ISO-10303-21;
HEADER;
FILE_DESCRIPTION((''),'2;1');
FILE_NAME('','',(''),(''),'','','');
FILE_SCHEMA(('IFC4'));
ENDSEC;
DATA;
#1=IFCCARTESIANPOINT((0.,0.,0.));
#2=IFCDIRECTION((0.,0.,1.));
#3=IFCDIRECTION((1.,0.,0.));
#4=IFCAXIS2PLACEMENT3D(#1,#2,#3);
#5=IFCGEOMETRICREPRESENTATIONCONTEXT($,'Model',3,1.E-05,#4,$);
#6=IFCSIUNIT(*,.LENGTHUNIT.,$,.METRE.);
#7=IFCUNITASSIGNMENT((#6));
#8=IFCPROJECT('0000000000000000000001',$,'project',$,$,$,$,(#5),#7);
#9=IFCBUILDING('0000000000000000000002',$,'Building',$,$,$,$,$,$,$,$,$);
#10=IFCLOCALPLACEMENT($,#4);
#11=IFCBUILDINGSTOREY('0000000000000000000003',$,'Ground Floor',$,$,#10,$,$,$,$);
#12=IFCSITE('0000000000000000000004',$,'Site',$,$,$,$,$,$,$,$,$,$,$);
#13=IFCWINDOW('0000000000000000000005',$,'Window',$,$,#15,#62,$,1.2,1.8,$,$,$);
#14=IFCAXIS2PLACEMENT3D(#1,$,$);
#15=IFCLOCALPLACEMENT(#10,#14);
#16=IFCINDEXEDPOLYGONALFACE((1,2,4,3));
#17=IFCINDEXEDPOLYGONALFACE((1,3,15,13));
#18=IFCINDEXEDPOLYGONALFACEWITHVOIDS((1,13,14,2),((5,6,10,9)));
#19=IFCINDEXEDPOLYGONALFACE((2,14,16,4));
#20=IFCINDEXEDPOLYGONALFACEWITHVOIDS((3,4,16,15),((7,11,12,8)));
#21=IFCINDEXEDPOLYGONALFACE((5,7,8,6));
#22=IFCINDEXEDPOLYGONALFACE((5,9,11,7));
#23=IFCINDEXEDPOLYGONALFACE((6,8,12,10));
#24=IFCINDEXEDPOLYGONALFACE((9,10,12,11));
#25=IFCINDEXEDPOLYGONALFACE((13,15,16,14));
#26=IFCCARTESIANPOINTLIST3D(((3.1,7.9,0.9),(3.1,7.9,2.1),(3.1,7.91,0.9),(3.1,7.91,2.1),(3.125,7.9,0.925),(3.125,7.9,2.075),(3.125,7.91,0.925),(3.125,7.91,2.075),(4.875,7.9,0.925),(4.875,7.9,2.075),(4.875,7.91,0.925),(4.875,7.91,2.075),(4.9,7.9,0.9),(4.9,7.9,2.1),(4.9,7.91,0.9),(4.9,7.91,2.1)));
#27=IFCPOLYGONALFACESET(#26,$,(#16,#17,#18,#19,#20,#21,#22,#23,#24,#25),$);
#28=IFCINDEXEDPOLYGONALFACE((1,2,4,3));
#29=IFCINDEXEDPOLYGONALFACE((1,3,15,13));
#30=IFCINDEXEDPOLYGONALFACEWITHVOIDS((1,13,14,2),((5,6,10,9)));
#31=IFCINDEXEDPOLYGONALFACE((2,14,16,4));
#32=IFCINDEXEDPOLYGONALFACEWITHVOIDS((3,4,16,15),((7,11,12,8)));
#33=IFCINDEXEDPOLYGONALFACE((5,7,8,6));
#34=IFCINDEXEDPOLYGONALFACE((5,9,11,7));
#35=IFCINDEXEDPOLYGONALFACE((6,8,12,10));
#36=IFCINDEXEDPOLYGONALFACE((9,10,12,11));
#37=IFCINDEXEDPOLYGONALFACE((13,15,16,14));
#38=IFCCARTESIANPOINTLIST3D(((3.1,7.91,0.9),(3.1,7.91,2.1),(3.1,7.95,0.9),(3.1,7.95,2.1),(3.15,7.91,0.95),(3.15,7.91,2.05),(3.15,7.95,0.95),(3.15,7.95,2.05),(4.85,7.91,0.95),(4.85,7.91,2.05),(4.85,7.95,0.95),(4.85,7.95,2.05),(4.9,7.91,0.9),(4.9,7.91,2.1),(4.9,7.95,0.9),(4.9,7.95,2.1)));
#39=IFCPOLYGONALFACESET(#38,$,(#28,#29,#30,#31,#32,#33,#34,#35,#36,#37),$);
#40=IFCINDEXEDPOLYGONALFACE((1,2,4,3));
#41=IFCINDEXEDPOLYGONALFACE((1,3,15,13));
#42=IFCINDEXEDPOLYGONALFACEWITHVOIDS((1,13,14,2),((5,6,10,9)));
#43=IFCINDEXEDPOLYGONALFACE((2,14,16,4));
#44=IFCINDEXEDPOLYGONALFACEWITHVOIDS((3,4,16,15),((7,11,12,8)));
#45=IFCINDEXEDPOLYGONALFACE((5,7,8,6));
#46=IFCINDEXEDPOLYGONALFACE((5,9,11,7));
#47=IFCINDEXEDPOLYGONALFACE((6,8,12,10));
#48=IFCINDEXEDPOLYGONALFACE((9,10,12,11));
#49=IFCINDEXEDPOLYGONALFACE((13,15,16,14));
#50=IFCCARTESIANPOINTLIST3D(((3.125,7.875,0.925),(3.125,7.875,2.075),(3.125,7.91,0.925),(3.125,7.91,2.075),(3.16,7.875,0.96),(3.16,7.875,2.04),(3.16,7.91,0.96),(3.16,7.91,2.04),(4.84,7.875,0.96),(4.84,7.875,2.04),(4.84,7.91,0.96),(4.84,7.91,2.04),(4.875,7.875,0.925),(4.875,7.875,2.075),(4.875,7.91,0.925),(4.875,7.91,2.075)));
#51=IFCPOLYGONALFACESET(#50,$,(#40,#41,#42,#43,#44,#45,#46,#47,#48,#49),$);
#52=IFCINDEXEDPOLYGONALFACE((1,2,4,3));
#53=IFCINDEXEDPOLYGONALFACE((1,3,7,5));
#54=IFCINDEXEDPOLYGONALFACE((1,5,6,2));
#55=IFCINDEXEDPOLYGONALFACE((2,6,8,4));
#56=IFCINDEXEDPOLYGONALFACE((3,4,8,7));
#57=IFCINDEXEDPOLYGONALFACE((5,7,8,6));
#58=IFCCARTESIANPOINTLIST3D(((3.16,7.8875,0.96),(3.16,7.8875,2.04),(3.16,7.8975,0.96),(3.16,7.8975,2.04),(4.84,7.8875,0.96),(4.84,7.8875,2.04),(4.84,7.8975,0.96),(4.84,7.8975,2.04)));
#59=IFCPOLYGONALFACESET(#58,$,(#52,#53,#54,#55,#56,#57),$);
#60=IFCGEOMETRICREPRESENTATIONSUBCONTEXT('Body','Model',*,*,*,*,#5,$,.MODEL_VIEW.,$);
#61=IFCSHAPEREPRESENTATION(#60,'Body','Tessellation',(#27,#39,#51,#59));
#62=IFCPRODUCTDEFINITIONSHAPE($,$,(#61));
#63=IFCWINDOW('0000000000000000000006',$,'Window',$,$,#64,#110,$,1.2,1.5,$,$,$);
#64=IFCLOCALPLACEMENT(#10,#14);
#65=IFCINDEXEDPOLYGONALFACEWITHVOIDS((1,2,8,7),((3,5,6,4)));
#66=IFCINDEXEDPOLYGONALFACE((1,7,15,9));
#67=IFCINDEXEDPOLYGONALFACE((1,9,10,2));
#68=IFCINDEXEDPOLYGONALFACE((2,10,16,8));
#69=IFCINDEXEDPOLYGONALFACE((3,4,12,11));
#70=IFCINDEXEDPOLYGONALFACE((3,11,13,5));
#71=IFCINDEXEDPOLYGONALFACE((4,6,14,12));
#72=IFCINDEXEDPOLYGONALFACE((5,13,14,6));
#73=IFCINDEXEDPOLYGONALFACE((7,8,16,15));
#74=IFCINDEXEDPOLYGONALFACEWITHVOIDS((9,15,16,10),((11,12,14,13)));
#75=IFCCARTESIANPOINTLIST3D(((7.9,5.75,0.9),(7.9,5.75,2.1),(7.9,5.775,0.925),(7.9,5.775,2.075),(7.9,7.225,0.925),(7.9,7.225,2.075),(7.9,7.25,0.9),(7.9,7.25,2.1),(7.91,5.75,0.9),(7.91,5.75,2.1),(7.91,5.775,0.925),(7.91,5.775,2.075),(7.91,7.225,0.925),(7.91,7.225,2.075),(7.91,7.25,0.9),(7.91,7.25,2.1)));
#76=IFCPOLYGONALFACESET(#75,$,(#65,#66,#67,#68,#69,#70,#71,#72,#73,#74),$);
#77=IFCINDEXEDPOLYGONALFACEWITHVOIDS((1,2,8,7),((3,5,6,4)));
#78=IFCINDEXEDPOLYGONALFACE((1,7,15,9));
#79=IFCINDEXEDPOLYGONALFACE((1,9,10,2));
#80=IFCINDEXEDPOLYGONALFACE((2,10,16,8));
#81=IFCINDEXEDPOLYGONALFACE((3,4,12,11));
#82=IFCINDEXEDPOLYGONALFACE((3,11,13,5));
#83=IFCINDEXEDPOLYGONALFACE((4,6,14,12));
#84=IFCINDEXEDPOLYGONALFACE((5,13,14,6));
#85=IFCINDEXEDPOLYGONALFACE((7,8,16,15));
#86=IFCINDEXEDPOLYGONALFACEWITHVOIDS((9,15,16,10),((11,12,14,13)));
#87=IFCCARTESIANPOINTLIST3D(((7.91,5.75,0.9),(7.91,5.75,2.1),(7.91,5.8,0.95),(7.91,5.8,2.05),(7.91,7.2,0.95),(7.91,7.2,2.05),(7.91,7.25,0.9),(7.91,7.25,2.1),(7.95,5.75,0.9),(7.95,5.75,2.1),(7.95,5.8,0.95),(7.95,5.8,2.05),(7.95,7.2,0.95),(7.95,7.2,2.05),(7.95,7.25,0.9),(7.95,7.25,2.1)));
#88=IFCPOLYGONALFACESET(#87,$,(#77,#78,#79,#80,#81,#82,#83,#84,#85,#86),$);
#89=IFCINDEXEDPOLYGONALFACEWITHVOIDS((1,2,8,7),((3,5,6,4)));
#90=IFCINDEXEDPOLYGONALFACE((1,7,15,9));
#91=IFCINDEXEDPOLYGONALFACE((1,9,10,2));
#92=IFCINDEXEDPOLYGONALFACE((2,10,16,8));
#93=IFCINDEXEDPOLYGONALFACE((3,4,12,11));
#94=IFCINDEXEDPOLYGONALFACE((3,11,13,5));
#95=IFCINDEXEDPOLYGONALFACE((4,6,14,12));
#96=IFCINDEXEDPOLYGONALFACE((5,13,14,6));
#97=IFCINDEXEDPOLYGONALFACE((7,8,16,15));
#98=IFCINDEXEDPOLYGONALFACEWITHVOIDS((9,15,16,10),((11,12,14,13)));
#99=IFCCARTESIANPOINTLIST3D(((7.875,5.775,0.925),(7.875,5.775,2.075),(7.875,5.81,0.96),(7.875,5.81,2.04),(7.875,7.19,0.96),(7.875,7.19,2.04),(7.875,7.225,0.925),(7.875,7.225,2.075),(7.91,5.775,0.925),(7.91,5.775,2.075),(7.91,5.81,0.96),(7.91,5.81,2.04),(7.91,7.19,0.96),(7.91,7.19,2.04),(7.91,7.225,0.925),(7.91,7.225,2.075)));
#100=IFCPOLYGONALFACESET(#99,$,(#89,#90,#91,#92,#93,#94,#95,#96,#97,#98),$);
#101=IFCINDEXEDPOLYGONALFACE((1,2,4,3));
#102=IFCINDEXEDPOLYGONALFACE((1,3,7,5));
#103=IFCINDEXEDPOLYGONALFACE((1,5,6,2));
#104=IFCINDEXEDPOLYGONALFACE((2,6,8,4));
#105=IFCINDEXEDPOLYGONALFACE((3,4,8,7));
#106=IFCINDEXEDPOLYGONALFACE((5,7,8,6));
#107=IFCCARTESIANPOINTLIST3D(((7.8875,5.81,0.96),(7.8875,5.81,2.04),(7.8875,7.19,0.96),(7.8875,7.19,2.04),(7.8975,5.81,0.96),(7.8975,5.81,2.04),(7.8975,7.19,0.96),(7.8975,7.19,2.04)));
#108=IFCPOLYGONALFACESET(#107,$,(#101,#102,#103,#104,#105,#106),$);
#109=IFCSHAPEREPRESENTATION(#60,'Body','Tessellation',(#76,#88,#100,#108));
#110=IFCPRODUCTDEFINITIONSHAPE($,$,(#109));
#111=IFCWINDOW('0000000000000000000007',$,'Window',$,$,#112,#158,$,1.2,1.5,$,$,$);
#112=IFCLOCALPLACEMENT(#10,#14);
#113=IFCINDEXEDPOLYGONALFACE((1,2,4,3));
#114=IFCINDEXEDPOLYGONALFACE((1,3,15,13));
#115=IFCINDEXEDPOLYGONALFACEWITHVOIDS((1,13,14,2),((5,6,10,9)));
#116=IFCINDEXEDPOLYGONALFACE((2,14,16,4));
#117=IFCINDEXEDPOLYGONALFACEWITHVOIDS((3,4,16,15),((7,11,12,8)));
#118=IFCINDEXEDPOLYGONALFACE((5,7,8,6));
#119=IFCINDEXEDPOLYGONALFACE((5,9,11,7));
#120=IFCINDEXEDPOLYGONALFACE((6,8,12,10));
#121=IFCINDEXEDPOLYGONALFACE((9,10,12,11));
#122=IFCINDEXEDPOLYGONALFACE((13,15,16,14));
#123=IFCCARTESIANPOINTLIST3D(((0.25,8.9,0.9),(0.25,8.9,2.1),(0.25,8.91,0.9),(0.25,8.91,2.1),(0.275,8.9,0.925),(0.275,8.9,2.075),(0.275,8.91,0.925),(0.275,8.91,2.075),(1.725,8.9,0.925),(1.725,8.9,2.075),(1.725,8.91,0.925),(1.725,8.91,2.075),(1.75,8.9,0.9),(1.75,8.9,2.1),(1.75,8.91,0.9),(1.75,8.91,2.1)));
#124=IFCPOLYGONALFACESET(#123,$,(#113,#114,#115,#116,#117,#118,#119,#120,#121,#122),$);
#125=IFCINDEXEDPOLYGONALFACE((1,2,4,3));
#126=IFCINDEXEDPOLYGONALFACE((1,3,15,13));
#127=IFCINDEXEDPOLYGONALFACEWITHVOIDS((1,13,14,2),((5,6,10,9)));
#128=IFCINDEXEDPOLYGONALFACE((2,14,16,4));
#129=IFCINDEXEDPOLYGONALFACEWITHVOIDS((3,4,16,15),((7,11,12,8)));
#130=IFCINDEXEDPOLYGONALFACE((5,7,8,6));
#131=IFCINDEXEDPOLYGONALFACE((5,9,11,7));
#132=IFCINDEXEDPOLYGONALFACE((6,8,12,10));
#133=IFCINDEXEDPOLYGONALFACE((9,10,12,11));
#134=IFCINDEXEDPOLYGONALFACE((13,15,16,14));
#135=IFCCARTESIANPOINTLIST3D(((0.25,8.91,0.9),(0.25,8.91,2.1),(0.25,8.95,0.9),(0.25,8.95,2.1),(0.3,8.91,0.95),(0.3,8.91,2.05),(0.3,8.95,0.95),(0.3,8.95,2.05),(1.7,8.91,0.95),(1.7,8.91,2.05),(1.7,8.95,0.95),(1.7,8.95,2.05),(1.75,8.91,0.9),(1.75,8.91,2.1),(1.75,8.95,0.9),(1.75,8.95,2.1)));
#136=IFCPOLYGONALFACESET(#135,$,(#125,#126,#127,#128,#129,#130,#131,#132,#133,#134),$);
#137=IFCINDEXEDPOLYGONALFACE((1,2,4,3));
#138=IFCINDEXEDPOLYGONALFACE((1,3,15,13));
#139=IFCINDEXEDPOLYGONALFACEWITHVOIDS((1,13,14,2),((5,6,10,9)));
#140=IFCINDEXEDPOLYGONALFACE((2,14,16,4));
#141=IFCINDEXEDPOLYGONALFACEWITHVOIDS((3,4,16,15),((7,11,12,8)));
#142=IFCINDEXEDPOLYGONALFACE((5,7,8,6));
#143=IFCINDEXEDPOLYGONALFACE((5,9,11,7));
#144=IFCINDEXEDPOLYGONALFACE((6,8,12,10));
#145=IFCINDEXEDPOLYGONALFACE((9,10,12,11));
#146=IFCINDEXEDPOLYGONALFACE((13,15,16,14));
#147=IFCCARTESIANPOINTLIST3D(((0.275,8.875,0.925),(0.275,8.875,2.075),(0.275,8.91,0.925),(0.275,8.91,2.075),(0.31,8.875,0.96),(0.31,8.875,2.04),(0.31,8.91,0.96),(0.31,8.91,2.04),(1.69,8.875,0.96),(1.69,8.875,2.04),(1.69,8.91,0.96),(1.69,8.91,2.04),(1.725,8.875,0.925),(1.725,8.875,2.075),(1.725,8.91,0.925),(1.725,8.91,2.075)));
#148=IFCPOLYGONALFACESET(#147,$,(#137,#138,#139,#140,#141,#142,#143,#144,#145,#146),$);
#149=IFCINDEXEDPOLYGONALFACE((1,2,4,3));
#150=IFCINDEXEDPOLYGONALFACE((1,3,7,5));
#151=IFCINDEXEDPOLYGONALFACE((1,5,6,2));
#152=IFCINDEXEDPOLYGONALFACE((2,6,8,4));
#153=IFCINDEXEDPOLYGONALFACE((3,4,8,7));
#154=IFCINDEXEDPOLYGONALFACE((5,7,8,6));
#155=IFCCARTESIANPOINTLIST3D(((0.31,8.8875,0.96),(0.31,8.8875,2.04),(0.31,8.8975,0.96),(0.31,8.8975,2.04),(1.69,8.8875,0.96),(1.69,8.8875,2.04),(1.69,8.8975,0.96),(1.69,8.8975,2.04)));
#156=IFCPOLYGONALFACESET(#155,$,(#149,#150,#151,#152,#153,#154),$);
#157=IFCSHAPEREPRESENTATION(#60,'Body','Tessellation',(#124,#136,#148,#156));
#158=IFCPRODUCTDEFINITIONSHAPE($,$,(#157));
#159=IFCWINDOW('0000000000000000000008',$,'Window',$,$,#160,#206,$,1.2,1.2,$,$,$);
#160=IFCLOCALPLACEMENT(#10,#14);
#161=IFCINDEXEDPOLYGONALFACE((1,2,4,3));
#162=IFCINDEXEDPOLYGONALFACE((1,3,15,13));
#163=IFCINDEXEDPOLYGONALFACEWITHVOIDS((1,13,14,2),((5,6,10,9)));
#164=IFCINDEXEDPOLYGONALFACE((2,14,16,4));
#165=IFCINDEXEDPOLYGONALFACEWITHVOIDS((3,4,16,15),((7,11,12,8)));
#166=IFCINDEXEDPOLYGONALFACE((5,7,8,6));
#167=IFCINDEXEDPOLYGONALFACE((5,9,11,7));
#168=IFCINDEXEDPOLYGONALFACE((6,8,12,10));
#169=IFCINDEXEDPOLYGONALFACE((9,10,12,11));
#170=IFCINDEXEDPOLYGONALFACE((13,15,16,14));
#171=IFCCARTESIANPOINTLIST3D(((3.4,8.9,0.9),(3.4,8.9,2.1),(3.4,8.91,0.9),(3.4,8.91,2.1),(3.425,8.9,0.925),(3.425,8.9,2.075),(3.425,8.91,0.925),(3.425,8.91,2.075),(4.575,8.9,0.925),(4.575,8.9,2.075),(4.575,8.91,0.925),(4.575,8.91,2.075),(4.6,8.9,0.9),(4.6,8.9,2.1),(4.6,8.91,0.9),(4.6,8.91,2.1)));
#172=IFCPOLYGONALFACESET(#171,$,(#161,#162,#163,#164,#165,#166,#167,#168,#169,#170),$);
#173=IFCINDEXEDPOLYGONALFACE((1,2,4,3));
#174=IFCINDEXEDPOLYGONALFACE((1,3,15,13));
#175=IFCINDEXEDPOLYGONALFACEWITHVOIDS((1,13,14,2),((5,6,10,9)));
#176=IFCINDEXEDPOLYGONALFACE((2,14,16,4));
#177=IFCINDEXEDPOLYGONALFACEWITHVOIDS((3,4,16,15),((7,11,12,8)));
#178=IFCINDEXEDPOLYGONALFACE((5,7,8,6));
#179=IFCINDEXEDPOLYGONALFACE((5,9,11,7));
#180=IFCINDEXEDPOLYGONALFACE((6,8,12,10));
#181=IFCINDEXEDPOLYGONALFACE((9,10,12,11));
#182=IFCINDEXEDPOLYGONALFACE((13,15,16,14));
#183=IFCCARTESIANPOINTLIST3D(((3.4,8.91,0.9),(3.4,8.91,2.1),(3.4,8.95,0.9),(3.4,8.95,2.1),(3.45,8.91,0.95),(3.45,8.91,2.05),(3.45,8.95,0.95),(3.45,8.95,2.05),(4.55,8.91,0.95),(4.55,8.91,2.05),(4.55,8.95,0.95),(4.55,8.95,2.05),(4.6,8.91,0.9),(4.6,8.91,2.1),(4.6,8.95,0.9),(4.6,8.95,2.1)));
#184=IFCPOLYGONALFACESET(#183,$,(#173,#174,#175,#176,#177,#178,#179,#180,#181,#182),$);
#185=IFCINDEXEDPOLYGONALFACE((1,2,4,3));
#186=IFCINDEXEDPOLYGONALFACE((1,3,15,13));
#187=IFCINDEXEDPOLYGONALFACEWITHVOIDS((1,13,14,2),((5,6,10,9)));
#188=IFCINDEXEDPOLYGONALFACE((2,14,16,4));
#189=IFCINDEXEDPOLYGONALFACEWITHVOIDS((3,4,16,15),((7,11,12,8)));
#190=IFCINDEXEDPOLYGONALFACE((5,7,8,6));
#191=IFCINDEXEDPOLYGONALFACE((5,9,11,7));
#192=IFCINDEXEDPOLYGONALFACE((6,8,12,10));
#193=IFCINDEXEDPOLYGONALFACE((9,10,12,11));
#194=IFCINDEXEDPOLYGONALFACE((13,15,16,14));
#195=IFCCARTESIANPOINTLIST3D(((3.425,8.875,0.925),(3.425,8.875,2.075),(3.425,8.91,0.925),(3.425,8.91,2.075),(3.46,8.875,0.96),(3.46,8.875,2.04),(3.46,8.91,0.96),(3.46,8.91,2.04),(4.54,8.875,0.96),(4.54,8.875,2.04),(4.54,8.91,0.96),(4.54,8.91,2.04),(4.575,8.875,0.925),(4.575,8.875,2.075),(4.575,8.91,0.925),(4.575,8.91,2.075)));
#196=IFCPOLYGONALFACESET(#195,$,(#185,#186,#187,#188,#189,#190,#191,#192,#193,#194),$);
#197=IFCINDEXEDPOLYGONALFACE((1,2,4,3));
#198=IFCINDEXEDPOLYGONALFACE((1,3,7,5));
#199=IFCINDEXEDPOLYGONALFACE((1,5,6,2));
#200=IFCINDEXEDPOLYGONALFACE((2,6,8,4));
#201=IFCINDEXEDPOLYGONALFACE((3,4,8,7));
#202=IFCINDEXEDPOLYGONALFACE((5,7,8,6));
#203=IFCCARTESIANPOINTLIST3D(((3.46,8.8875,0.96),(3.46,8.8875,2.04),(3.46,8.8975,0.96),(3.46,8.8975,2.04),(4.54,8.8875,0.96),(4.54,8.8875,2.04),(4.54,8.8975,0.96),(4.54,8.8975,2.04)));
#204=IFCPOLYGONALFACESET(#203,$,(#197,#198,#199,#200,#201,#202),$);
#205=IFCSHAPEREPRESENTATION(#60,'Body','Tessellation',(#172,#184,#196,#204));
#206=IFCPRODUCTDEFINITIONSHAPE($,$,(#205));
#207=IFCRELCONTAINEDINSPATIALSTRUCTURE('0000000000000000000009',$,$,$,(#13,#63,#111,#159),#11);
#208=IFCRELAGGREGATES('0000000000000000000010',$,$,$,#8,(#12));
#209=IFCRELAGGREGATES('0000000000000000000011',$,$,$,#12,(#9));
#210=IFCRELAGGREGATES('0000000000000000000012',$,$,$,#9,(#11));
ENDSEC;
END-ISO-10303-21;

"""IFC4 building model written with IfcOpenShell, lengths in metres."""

from ifc_helpers import new_model, si_unit, frame, origin_with_axes, place, context, subcontext, project, spatial, line, indexed_curve, outline, extrude, element, save


model = new_model("IFC4")

# Units and contexts
model_context = context("Model", 3, precision=1e-05, world=origin_with_axes())
body_context = subcontext(model_context, "Body", "Model", "MODEL_VIEW")
ifc_project = project(units=[si_unit("LENGTHUNIT", "METRE")], contexts=[model_context])

# Site, building, storey
site = spatial("IfcSite", under=ifc_project, Name="Site")
building = spatial("IfcBuilding", under=site, Name="Building")
storey_placement = place(None, origin_with_axes())
storey = spatial("IfcBuildingStorey", under=building, at=storey_placement, Name="Ground Floor")

# Windows
window_1_placement = place(storey_placement, frame((4.9, 8.0, 0.9), z_axis=(0.0, 0.0, 1.0), x_axis=(-1.0, 0.0, 0.0)))
element("IfcWindow", 1, at=window_1_placement, inside=storey, Name="Window", OverallHeight=1.2, OverallWidth=1.8, context=body_context, shape_type="SweptSolid", body=[
    extrude(outline(indexed_curve([(0.0, 0.0), (1.8, 0.0), (1.8, 1.2), (0.0, 1.2)], segments=[line(1, 2, 3, 4, 1)]), holes=[indexed_curve([(0.025, 0.025), (1.775, 0.025), (1.775, 1.175), (0.025, 1.175)], segments=[line(1, 2, 3, 4, 1)])]), frame((0.0, 0.09, 0.0), z_axis=(0.0, -1.0, 0.0), x_axis=(1.0, 0.0, 0.0)), (0.0, 0.0, -1.0), 0.01),
    extrude(outline(indexed_curve([(0.0, 0.0), (1.8, 0.0), (1.8, 1.2), (0.0, 1.2)], segments=[line(1, 2, 3, 4, 1)]), holes=[indexed_curve([(0.05, 0.05), (1.75, 0.05), (1.75, 1.15), (0.05, 1.15)], segments=[line(1, 2, 3, 4, 1)])]), frame((0.0, 0.05, 0.0), z_axis=(0.0, -1.0, 0.0), x_axis=(1.0, 0.0, 0.0)), (0.0, 0.0, -1.0), 0.04),
    extrude(outline(indexed_curve([(0.0, 0.0), (1.75, 0.0), (1.75, 1.15), (0.0, 1.15)], segments=[line(1, 2, 3, 4, 1)]), holes=[indexed_curve([(0.035, 0.035), (1.715, 0.035), (1.715, 1.115), (0.035, 1.115)], segments=[line(1, 2, 3, 4, 1)])]), frame((0.025, 0.09, 0.025), z_axis=(0.0, -1.0, 0.0), x_axis=(1.0, 0.0, 0.0)), (0.0, 0.0, -1.0), 0.035),
    extrude(outline(indexed_curve([(0.035, 0.035), (1.715, 0.035), (1.715, 1.115), (0.035, 1.115)], segments=[line(1, 2, 3, 4, 1)])), frame((0.025, 0.1025, 0.025), z_axis=(0.0, -1.0, 0.0), x_axis=(1.0, 0.0, 0.0)), (0.0, 0.0, -1.0), 0.01),
])
for number, where, z_axis, x_axis, name in (
    (2, (8.0, 5.75, 0.9), (0.0, 0.0, 1.0), (0.0, 1.0, 0.0), "Window"),
    (3, (1.75, 9.0, 0.9), (0.0, 0.0, 1.0), (-1.0, 0.0, 0.0), "Window"),
):
    element("IfcWindow", number, at=place(storey_placement, frame(where, z_axis=z_axis, x_axis=x_axis)), inside=storey, Name=name, OverallHeight=1.2, OverallWidth=1.5, context=body_context, shape_type="SweptSolid", body=[
        extrude(outline(indexed_curve([(0.0, 0.0), (1.5, 0.0), (1.5, 1.2), (0.0, 1.2)], segments=[line(1, 2, 3, 4, 1)]), holes=[indexed_curve([(0.025, 0.025), (1.475, 0.025), (1.475, 1.175), (0.025, 1.175)], segments=[line(1, 2, 3, 4, 1)])]), frame((0.0, 0.09, 0.0), z_axis=(0.0, -1.0, 0.0), x_axis=(1.0, 0.0, 0.0)), (0.0, 0.0, -1.0), 0.01),
        extrude(outline(indexed_curve([(0.0, 0.0), (1.5, 0.0), (1.5, 1.2), (0.0, 1.2)], segments=[line(1, 2, 3, 4, 1)]), holes=[indexed_curve([(0.05, 0.05), (1.45, 0.05), (1.45, 1.15), (0.05, 1.15)], segments=[line(1, 2, 3, 4, 1)])]), frame((0.0, 0.05, 0.0), z_axis=(0.0, -1.0, 0.0), x_axis=(1.0, 0.0, 0.0)), (0.0, 0.0, -1.0), 0.04),
        extrude(outline(indexed_curve([(0.0, 0.0), (1.45, 0.0), (1.45, 1.15), (0.0, 1.15)], segments=[line(1, 2, 3, 4, 1)]), holes=[indexed_curve([(0.035, 0.035), (1.415, 0.035), (1.415, 1.115), (0.035, 1.115)], segments=[line(1, 2, 3, 4, 1)])]), frame((0.025, 0.09, 0.025), z_axis=(0.0, -1.0, 0.0), x_axis=(1.0, 0.0, 0.0)), (0.0, 0.0, -1.0), 0.035),
        extrude(outline(indexed_curve([(0.035, 0.035), (1.415, 0.035), (1.415, 1.115), (0.035, 1.115)], segments=[line(1, 2, 3, 4, 1)])), frame((0.025, 0.1025, 0.025), z_axis=(0.0, -1.0, 0.0), x_axis=(1.0, 0.0, 0.0)), (0.0, 0.0, -1.0), 0.01),
    ])
window_2_placement = place(storey_placement, frame((4.6, 9.0, 0.9), z_axis=(0.0, 0.0, 1.0), x_axis=(-1.0, 0.0, 0.0)))
element("IfcWindow", 4, at=window_2_placement, inside=storey, Name="Window", OverallHeight=1.2, OverallWidth=1.2, context=body_context, shape_type="SweptSolid", body=[
    extrude(outline(indexed_curve([(0.0, 0.0), (1.2, 0.0), (1.2, 1.2), (0.0, 1.2)], segments=[line(1, 2, 3, 4, 1)]), holes=[indexed_curve([(0.025, 0.025), (1.175, 0.025), (1.175, 1.175), (0.025, 1.175)], segments=[line(1, 2, 3, 4, 1)])]), frame((0.0, 0.09, 0.0), z_axis=(0.0, -1.0, 0.0), x_axis=(1.0, 0.0, 0.0)), (0.0, 0.0, -1.0), 0.01),
    extrude(outline(indexed_curve([(0.0, 0.0), (1.2, 0.0), (1.2, 1.2), (0.0, 1.2)], segments=[line(1, 2, 3, 4, 1)]), holes=[indexed_curve([(0.05, 0.05), (1.15, 0.05), (1.15, 1.15), (0.05, 1.15)], segments=[line(1, 2, 3, 4, 1)])]), frame((0.0, 0.05, 0.0), z_axis=(0.0, -1.0, 0.0), x_axis=(1.0, 0.0, 0.0)), (0.0, 0.0, -1.0), 0.04),
    extrude(outline(indexed_curve([(0.0, 0.0), (1.15, 0.0), (1.15, 1.15), (0.0, 1.15)], segments=[line(1, 2, 3, 4, 1)]), holes=[indexed_curve([(0.035, 0.035), (1.115, 0.035), (1.115, 1.115), (0.035, 1.115)], segments=[line(1, 2, 3, 4, 1)])]), frame((0.025, 0.09, 0.025), z_axis=(0.0, -1.0, 0.0), x_axis=(1.0, 0.0, 0.0)), (0.0, 0.0, -1.0), 0.035),
    extrude(outline(indexed_curve([(0.035, 0.035), (1.115, 0.035), (1.115, 1.115), (0.035, 1.115)], segments=[line(1, 2, 3, 4, 1)])), frame((0.025, 0.1025, 0.025), z_axis=(0.0, -1.0, 0.0), x_axis=(1.0, 0.0, 0.0)), (0.0, 0.0, -1.0), 0.01),
])

save(model, "model.ifc")
